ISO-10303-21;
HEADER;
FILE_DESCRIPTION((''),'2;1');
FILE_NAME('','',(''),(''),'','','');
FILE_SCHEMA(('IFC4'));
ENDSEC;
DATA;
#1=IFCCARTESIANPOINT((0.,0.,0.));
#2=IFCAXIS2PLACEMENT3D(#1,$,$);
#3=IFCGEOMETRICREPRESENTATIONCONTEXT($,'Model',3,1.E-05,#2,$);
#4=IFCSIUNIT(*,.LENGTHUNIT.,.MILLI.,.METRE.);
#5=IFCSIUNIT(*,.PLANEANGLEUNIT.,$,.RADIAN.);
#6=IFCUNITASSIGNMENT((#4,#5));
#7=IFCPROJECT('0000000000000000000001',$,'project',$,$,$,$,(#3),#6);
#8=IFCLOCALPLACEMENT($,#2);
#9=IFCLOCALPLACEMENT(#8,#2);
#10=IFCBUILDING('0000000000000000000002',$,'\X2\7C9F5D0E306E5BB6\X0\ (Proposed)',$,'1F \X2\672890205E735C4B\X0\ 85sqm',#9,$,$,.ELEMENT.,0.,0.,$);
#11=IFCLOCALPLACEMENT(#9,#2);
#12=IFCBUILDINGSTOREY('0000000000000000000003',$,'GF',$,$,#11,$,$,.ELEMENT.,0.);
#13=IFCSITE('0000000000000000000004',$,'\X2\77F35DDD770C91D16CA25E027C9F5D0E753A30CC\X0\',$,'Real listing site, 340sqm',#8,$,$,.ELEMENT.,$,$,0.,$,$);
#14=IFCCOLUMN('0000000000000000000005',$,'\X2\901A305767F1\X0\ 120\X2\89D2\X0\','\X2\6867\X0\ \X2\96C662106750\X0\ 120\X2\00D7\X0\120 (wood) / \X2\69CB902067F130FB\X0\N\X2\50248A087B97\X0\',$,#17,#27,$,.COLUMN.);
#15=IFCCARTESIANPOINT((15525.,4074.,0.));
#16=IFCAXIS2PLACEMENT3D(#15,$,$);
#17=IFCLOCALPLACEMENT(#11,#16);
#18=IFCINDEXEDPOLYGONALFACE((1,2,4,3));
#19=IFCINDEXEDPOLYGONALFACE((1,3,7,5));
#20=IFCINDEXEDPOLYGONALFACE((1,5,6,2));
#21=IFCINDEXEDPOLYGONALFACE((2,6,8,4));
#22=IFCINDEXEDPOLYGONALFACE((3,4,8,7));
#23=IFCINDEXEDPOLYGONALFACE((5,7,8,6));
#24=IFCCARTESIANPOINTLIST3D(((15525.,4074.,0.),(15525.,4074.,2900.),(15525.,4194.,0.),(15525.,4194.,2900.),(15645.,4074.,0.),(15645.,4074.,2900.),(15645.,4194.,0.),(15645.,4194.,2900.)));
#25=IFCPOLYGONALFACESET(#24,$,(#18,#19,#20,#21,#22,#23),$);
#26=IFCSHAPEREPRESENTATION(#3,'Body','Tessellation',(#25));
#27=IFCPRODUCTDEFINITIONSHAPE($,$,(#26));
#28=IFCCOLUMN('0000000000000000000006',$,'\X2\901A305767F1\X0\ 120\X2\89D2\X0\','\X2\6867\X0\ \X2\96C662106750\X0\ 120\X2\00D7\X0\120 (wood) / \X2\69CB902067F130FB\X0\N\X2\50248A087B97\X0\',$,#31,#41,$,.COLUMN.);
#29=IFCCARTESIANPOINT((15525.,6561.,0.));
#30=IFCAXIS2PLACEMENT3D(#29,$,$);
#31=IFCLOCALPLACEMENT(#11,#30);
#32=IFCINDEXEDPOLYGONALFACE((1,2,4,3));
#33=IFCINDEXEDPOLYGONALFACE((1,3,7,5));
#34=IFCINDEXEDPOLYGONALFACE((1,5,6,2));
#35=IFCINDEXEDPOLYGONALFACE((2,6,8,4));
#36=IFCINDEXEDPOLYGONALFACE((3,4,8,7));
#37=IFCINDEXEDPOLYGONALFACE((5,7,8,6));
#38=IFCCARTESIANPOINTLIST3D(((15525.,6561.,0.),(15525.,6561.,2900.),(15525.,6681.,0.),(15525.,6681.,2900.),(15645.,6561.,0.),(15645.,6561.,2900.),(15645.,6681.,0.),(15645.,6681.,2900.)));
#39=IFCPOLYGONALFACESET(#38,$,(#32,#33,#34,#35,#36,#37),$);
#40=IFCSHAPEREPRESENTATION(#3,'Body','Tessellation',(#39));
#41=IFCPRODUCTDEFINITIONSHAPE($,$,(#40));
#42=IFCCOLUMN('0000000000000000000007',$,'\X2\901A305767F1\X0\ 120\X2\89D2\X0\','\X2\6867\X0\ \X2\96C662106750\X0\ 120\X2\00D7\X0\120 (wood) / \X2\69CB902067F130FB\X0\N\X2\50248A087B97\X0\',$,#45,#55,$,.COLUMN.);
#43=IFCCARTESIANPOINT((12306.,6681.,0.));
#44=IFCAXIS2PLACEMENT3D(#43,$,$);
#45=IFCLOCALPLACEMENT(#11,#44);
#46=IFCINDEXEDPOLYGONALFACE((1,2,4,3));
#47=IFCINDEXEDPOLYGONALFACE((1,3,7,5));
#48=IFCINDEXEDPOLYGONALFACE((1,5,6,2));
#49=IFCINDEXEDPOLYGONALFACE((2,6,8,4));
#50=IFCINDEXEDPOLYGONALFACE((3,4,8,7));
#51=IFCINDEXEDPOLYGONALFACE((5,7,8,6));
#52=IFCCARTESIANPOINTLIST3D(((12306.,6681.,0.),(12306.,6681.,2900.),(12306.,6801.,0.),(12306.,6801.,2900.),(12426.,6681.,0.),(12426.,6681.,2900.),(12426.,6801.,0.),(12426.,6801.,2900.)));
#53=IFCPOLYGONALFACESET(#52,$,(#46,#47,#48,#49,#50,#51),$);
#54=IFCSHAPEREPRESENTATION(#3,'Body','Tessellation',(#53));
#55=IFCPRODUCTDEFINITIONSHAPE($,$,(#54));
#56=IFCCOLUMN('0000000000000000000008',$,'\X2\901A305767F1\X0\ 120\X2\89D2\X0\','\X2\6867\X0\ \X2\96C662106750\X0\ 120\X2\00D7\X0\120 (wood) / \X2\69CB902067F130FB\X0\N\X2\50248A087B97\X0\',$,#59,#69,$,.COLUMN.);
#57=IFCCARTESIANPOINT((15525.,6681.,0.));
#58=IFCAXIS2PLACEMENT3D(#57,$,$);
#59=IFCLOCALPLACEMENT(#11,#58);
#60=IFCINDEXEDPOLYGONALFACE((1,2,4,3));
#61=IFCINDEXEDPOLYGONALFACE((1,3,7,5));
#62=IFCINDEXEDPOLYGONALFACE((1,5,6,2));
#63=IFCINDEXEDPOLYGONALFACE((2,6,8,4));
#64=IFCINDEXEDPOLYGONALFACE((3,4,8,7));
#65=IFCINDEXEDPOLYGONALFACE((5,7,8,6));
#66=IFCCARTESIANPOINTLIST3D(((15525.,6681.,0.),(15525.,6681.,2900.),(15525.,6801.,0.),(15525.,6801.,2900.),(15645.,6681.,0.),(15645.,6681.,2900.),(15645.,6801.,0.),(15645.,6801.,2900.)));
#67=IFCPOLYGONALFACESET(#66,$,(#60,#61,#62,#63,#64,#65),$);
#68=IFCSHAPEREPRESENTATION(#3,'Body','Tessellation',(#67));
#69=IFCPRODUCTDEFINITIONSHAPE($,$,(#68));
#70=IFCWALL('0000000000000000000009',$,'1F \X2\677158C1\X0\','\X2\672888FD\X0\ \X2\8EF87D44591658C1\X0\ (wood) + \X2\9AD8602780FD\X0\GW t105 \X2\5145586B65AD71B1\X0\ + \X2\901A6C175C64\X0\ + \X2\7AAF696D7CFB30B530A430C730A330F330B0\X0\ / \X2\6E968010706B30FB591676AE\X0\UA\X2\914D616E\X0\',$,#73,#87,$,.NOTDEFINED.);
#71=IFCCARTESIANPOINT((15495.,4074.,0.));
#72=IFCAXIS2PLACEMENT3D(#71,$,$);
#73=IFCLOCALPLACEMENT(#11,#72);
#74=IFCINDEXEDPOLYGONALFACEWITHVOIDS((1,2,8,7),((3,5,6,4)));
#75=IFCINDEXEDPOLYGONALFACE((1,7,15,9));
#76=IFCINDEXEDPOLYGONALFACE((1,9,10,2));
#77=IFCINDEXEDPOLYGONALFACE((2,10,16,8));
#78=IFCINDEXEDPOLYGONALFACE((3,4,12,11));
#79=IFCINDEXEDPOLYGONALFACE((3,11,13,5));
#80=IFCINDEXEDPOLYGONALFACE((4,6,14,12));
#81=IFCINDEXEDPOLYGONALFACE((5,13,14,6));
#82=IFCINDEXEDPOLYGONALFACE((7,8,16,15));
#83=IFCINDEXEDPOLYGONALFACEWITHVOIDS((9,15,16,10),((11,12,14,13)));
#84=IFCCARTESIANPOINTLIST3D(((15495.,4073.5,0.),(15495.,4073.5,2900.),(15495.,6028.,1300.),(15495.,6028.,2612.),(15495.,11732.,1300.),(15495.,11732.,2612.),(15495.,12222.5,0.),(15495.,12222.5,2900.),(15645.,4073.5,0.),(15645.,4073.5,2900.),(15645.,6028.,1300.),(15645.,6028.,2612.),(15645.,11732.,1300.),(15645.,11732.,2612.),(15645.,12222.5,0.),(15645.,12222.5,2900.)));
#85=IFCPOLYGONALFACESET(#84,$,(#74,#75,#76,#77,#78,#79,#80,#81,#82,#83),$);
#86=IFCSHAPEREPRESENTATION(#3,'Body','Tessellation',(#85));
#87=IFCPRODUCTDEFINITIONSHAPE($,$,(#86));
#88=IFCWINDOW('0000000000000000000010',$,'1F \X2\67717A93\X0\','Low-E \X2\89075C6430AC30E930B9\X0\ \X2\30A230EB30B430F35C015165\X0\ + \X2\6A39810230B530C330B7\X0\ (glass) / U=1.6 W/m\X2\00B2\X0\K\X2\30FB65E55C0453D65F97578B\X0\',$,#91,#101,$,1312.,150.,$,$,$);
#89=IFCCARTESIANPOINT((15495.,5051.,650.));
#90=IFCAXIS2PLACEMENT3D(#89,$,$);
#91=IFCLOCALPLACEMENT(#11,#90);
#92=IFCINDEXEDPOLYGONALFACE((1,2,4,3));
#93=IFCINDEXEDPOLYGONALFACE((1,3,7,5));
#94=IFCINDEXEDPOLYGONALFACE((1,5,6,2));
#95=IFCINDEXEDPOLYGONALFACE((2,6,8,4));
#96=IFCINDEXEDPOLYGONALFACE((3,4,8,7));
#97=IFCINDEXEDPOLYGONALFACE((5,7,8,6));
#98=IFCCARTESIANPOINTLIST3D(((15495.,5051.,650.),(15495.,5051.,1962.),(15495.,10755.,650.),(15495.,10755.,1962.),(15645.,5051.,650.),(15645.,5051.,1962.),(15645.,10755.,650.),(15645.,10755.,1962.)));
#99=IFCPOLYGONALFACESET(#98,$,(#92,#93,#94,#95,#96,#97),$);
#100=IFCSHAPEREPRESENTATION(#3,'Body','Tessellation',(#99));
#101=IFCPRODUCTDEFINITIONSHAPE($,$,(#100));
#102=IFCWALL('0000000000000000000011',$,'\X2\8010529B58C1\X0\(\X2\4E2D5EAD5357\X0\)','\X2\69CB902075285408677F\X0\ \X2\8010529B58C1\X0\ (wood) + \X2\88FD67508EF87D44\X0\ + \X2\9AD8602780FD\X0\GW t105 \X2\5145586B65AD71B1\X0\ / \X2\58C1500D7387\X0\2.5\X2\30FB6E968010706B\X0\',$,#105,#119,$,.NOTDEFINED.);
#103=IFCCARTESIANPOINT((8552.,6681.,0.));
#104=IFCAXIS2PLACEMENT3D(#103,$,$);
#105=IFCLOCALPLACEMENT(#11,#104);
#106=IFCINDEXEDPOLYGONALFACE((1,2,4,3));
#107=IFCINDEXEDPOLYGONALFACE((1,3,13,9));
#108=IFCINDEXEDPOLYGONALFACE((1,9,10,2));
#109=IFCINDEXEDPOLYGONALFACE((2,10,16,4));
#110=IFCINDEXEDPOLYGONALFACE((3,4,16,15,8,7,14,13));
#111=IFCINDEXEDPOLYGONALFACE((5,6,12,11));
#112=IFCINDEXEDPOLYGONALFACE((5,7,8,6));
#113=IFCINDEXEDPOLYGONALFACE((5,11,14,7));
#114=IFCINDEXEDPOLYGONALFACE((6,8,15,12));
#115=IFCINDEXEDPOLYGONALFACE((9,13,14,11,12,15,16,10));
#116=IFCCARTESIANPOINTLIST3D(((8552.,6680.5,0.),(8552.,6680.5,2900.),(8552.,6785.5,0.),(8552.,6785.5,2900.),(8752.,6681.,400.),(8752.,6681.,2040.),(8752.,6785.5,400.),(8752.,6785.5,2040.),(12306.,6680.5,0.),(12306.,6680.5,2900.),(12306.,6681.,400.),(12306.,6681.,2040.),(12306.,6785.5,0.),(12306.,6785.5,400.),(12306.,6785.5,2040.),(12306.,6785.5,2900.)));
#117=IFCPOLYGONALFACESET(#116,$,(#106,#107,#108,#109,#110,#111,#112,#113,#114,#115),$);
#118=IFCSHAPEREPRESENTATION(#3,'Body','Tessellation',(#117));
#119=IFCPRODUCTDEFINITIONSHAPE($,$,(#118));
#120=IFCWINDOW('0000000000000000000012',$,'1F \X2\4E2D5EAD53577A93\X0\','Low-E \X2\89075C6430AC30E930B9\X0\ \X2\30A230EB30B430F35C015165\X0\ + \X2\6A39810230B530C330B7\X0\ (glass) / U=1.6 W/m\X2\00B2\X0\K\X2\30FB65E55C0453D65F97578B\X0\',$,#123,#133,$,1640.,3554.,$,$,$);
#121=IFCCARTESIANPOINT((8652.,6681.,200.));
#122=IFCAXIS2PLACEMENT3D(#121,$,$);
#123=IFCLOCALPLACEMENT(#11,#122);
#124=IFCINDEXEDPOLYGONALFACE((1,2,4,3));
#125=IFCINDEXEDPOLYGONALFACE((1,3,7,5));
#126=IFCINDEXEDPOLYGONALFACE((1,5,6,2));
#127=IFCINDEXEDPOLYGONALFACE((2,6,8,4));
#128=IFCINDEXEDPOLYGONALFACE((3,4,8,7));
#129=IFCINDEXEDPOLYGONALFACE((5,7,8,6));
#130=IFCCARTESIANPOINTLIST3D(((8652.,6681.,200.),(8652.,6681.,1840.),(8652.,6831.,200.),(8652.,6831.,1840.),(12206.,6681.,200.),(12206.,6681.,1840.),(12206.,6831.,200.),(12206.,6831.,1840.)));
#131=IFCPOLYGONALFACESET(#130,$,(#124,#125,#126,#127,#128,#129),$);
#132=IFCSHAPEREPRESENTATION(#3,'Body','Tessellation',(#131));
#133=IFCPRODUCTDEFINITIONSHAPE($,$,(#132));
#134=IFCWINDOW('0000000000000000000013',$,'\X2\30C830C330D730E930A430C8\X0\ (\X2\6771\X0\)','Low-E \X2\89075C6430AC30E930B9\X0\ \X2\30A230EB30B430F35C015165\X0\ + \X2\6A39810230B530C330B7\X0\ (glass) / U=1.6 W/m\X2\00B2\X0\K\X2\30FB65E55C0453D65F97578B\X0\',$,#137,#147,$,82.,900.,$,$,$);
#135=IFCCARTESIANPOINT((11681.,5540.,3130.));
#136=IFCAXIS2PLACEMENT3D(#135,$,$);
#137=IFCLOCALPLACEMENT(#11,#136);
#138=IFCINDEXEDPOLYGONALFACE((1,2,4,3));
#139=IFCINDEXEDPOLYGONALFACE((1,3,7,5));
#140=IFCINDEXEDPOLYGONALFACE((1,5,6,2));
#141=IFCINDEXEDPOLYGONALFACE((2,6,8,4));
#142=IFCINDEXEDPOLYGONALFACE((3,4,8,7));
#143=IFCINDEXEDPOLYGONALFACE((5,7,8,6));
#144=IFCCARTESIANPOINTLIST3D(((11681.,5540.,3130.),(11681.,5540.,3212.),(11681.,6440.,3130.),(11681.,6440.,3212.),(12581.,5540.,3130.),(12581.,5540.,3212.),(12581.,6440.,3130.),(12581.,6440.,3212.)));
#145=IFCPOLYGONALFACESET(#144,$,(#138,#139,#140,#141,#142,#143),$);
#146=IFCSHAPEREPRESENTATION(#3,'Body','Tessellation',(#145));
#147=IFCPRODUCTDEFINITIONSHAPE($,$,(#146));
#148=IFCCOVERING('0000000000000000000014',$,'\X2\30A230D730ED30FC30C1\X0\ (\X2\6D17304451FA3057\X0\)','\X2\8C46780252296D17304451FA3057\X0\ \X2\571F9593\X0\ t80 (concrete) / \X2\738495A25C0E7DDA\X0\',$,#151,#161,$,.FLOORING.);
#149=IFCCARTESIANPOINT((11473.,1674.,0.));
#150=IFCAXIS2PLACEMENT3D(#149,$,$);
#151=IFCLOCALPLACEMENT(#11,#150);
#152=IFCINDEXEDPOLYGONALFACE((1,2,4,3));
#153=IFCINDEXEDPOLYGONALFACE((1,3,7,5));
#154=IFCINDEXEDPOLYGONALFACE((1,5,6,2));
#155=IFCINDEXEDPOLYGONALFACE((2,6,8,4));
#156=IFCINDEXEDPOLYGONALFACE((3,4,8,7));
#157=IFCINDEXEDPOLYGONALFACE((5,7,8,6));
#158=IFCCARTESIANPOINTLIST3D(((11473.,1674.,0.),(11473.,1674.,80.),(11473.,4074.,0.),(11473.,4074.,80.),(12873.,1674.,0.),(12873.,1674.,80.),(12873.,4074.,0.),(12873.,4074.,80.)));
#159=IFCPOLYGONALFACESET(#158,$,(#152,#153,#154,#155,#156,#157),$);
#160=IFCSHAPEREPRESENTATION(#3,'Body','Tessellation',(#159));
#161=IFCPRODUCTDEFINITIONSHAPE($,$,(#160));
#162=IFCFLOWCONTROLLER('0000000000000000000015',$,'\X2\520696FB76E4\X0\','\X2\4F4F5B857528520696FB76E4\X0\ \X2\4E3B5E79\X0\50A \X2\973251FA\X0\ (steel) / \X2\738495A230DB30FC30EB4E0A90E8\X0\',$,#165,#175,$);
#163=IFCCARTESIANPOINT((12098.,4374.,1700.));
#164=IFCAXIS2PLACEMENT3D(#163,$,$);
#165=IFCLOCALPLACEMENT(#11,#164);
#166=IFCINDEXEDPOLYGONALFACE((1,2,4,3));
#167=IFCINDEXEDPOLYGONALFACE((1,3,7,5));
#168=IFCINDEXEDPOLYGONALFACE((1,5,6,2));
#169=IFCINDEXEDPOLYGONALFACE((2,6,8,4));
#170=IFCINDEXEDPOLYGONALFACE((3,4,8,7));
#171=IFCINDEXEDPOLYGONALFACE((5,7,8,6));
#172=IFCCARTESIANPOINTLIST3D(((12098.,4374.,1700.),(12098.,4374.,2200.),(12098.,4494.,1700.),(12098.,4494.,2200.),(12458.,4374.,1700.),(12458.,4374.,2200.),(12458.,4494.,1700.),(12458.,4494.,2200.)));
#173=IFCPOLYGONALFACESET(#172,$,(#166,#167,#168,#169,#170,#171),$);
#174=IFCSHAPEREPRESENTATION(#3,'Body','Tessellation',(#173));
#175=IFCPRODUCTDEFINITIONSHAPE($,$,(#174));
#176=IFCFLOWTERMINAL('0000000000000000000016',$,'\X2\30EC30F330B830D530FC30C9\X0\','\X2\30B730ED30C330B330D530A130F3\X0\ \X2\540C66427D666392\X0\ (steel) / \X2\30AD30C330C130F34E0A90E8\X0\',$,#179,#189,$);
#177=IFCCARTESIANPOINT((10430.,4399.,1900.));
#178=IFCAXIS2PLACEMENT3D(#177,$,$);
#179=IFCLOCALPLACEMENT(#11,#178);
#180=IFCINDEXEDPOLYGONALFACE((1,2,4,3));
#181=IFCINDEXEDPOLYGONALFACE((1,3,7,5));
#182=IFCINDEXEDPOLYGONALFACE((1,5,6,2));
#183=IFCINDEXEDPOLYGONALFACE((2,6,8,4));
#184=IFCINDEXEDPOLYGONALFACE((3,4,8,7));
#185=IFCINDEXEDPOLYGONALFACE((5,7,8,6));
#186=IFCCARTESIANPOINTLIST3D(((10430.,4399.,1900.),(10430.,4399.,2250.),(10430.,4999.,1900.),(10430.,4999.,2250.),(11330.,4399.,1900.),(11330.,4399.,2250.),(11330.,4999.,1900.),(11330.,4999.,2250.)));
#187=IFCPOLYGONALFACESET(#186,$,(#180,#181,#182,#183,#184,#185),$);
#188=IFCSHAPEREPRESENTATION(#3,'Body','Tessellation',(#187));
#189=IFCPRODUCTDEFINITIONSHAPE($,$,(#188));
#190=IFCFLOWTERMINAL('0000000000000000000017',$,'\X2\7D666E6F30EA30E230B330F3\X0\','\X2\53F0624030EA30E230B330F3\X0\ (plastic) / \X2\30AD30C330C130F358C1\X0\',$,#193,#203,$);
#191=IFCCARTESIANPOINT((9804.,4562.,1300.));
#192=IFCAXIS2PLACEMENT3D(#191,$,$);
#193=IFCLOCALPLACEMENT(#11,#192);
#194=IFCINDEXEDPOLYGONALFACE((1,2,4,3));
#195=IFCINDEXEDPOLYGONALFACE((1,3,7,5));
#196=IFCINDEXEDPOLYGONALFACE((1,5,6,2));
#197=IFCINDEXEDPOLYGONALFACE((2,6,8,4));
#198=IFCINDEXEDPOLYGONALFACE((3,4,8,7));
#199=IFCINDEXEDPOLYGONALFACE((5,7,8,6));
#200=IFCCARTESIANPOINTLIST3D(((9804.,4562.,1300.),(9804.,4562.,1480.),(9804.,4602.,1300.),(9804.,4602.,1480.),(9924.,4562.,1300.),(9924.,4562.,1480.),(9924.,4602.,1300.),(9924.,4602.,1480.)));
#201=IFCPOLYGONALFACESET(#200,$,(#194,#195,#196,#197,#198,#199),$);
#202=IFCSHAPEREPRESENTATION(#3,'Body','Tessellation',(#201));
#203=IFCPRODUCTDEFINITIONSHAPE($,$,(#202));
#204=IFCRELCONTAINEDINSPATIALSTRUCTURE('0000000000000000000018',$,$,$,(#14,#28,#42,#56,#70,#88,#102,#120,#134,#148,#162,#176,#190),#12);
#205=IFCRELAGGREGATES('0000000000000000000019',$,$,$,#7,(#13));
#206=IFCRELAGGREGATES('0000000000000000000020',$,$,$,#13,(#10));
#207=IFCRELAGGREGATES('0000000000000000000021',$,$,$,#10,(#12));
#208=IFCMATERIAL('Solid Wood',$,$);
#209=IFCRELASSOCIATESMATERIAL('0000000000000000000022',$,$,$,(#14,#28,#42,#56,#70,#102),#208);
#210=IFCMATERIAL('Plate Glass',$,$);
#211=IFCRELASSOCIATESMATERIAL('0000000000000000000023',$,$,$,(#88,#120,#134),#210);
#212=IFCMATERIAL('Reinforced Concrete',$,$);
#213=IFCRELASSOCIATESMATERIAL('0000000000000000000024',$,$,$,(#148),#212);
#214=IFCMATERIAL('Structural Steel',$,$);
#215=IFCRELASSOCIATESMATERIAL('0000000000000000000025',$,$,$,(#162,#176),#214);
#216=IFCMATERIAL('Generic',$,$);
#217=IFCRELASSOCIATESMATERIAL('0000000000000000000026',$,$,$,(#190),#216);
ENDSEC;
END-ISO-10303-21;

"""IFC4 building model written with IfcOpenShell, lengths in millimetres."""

from ifc_helpers import new_model, si_unit, frame, frame_2d, origin, place, context, project, spatial, rectangle, extrude, material, element, fill, save


model = new_model("IFC4")

# Units and contexts
model_context = context("Model", 3, precision=1e-05, world=origin())
ifc_project = project(units=[si_unit("LENGTHUNIT", "METRE", prefix="MILLI"), si_unit("PLANEANGLEUNIT", "RADIAN")], contexts=[model_context])

# Site, building, storey
site_placement = place(None, origin())
site = spatial("IfcSite", under=ifc_project, at=site_placement, Name="石川県金沢市粟崎町ヌ", ObjectType="Real listing site, 340sqm", CompositionType="ELEMENT", RefElevation=0.0)
building_placement = place(site_placement, origin())
building = spatial("IfcBuilding", under=site, at=building_placement, Name="粟崎の家 (Proposed)", ObjectType="1F 木造平屋 85sqm", CompositionType="ELEMENT", ElevationOfRefHeight=0.0, ElevationOfTerrain=0.0)
storey_placement = place(building_placement, origin())
storey = spatial("IfcBuildingStorey", under=building, at=storey_placement, Name="GF", CompositionType="ELEMENT", Elevation=0.0)

# Columns
ifc_material_1 = material(Name="Solid Wood")
column_1_placement = place(storey_placement, frame((15525.0, 4074.0, 0.0)))
element("IfcColumn", 1, at=column_1_placement, inside=storey, material=ifc_material_1, Name="通し柱 120角", Description="桧 集成材 120×120 (wood) / 構造柱・N値計算", PredefinedType="COLUMN", context=model_context, shape_type="SweptSolid", body=[
    extrude(rectangle(XDim=120.0, YDim=120.0, at=frame_2d((60.0, 60.0))), frame((15525.0, 4074.0, 0.0)), (0.0, 0.0, 1.0), 2900.0),
])
column_2_placement = place(storey_placement, frame((15525.0, 6561.0, 0.0)))
element("IfcColumn", 2, at=column_2_placement, inside=storey, material=ifc_material_1, Name="通し柱 120角", Description="桧 集成材 120×120 (wood) / 構造柱・N値計算", PredefinedType="COLUMN", context=model_context, shape_type="SweptSolid", body=[
    extrude(rectangle(XDim=120.0, YDim=120.0, at=frame_2d((60.0, 60.0))), frame((15525.0, 6561.0, 0.0)), (0.0, 0.0, 1.0), 2900.0),
])
column_3_placement = place(storey_placement, frame((12306.0, 6681.0, 0.0)))
element("IfcColumn", 3, at=column_3_placement, inside=storey, material=ifc_material_1, Name="通し柱 120角", Description="桧 集成材 120×120 (wood) / 構造柱・N値計算", PredefinedType="COLUMN", context=model_context, shape_type="SweptSolid", body=[
    extrude(rectangle(XDim=120.0, YDim=120.0, at=frame_2d((60.0, 60.0))), frame((12306.0, 6681.0, 0.0)), (0.0, 0.0, 1.0), 2900.0),
])
column_4_placement = place(storey_placement, frame((15525.0, 6681.0, 0.0)))
element("IfcColumn", 4, at=column_4_placement, inside=storey, material=ifc_material_1, Name="通し柱 120角", Description="桧 集成材 120×120 (wood) / 構造柱・N値計算", PredefinedType="COLUMN", context=model_context, shape_type="SweptSolid", body=[
    extrude(rectangle(XDim=120.0, YDim=120.0, at=frame_2d((60.0, 60.0))), frame((15525.0, 6681.0, 0.0)), (0.0, 0.0, 1.0), 2900.0),
])

# Walls, openings, windows
wall_1_placement = place(storey_placement, frame((15495.0, 4074.0, 0.0)))
wall_1 = element("IfcWall", 5, at=wall_1_placement, inside=storey, material=ifc_material_1, Name="1F 東壁", Description="木製 軸組外壁 (wood) + 高性能GW t105 充填断熱 + 通気層 + 窯業系サイディング / 準耐火・外皮UA配慮", PredefinedType="NOTDEFINED", context=model_context, shape_type="SweptSolid", body=[
    extrude(rectangle(XDim=150.0, YDim=8149.0, at=frame_2d((75.0, 4074.0))), frame((15495.0, 4074.0, 0.0)), (0.0, 0.0, 1.0), 2900.0),
])
opening_1_placement = place(storey_placement, frame((15495.0, 5051.0, 650.0)))
opening_1 = element("IfcOpeningElement", 6, at=opening_1_placement, cuts=wall_1, PredefinedType="NOTDEFINED", context=model_context, shape_type="SweptSolid", body=[
    extrude(rectangle(XDim=150.0, YDim=5704.0, at=frame_2d((75.0, 2852.0))), frame((15495.0, 5051.0, 650.0)), (0.0, 0.0, 1.0), 1312.0),
])
ifc_material_2 = material(Name="Plate Glass")
window_1_placement = place(storey_placement, frame((15495.0, 5051.0, 650.0)))
window_1 = element("IfcWindow", 7, at=window_1_placement, inside=storey, material=ifc_material_2, Name="1F 東窓", Description="Low-E 複層ガラス アルゴン封入 + 樹脂サッシ (glass) / U=1.6 W/m²K・日射取得型", OverallHeight=1312.0, OverallWidth=150.0, context=model_context, shape_type="SweptSolid", body=[
    extrude(rectangle(XDim=150.0, YDim=5704.0, at=frame_2d((75.0, 2852.0))), frame((15495.0, 5051.0, 650.0)), (0.0, 0.0, 1.0), 1312.0),
])
fill(opening_1, window_1)
wall_2_placement = place(storey_placement, frame((8552.0, 6681.0, 0.0)))
wall_2 = element("IfcWall", 8, at=wall_2_placement, inside=storey, material=ifc_material_1, Name="耐力壁(中庭南)", Description="構造用合板 耐力壁 (wood) + 製材軸組 + 高性能GW t105 充填断熱 / 壁倍率2.5・準耐火", PredefinedType="NOTDEFINED", context=model_context, shape_type="SweptSolid", body=[
    extrude(rectangle(XDim=3754.0, YDim=105.0, at=frame_2d((1877.0, 52.0))), frame((8552.0, 6681.0, 0.0)), (0.0, 0.0, 1.0), 2900.0),
])
opening_2_placement = place(storey_placement, frame((8652.0, 6681.0, 200.0)))
opening_2 = element("IfcOpeningElement", 9, at=opening_2_placement, cuts=wall_2, PredefinedType="NOTDEFINED", context=model_context, shape_type="SweptSolid", body=[
    extrude(rectangle(XDim=3554.0, YDim=150.0, at=frame_2d((1777.0, 75.0))), frame((8652.0, 6681.0, 200.0)), (0.0, 0.0, 1.0), 1640.0),
])
window_2_placement = place(storey_placement, frame((8652.0, 6681.0, 200.0)))
window_2 = element("IfcWindow", 10, at=window_2_placement, inside=storey, material=ifc_material_2, Name="1F 中庭南窓", Description="Low-E 複層ガラス アルゴン封入 + 樹脂サッシ (glass) / U=1.6 W/m²K・日射取得型", OverallHeight=1640.0, OverallWidth=3554.0, context=model_context, shape_type="SweptSolid", body=[
    extrude(rectangle(XDim=3554.0, YDim=150.0, at=frame_2d((1777.0, 75.0))), frame((8652.0, 6681.0, 200.0)), (0.0, 0.0, 1.0), 1640.0),
])
fill(opening_2, window_2)

# Window
window_3_placement = place(storey_placement, frame((11681.0, 5540.0, 3130.0)))
element("IfcWindow", 11, at=window_3_placement, inside=storey, material=ifc_material_2, Name="トップライト (東)", Description="Low-E 複層ガラス アルゴン封入 + 樹脂サッシ (glass) / U=1.6 W/m²K・日射取得型", OverallHeight=82.0, OverallWidth=900.0, context=model_context, shape_type="SweptSolid", body=[
    extrude(rectangle(XDim=900.0, YDim=900.0, at=frame_2d((450.0, 450.0))), frame((11681.0, 5540.0, 3130.0)), (0.0, 0.0, 1.0), 82.0),
])

# Shared definitions
ifc_material_3 = material(Name="Structural Steel")

# Covering
ifc_material_4 = material(Name="Reinforced Concrete")
covering_placement = place(storey_placement, frame((11473.0, 1674.0, 0.0)))
element("IfcCovering", 12, at=covering_placement, inside=storey, material=ifc_material_4, Name="アプローチ (洗い出し)", Description="豆砂利洗い出し 土間 t80 (concrete) / 玄関導線", PredefinedType="FLOORING", context=model_context, shape_type="SweptSolid", body=[
    extrude(rectangle(XDim=1400.0, YDim=2400.0, at=frame_2d((700.0, 1200.0))), frame((11473.0, 1674.0, 0.0)), (0.0, 0.0, 1.0), 80.0),
])

# Flow controller
flow_controller_placement = place(storey_placement, frame((12098.0, 4374.0, 1700.0)))
element("IfcFlowController", 13, at=flow_controller_placement, inside=storey, material=ifc_material_3, Name="分電盤", Description="住宅用分電盤 主幹50A 露出 (steel) / 玄関ホール上部", context=model_context, shape_type="SweptSolid", body=[
    extrude(rectangle(XDim=360.0, YDim=120.0, at=frame_2d((180.0, 60.0))), frame((12098.0, 4374.0, 1700.0)), (0.0, 0.0, 1.0), 500.0),
])

# Flow terminals
flow_terminal_1_placement = place(storey_placement, frame((10430.0, 4399.0, 1900.0)))
element("IfcFlowTerminal", 14, at=flow_terminal_1_placement, inside=storey, material=ifc_material_3, Name="レンジフード", Description="シロッコファン 同時給排 (steel) / キッチン上部", context=model_context, shape_type="SweptSolid", body=[
    extrude(rectangle(XDim=900.0, YDim=600.0, at=frame_2d((450.0, 300.0))), frame((10430.0, 4399.0, 1900.0)), (0.0, 0.0, 1.0), 350.0),
])
ifc_material_5 = material(Name="Generic")
flow_terminal_2_placement = place(storey_placement, frame((9804.0, 4562.0, 1300.0)))
element("IfcFlowTerminal", 15, at=flow_terminal_2_placement, inside=storey, material=ifc_material_5, Name="給湯リモコン", Description="台所リモコン (plastic) / キッチン壁", context=model_context, shape_type="SweptSolid", body=[
    extrude(rectangle(XDim=120.0, YDim=40.0, at=frame_2d((60.0, 20.0))), frame((9804.0, 4562.0, 1300.0)), (0.0, 0.0, 1.0), 180.0),
])

save(model, "model.ifc")
